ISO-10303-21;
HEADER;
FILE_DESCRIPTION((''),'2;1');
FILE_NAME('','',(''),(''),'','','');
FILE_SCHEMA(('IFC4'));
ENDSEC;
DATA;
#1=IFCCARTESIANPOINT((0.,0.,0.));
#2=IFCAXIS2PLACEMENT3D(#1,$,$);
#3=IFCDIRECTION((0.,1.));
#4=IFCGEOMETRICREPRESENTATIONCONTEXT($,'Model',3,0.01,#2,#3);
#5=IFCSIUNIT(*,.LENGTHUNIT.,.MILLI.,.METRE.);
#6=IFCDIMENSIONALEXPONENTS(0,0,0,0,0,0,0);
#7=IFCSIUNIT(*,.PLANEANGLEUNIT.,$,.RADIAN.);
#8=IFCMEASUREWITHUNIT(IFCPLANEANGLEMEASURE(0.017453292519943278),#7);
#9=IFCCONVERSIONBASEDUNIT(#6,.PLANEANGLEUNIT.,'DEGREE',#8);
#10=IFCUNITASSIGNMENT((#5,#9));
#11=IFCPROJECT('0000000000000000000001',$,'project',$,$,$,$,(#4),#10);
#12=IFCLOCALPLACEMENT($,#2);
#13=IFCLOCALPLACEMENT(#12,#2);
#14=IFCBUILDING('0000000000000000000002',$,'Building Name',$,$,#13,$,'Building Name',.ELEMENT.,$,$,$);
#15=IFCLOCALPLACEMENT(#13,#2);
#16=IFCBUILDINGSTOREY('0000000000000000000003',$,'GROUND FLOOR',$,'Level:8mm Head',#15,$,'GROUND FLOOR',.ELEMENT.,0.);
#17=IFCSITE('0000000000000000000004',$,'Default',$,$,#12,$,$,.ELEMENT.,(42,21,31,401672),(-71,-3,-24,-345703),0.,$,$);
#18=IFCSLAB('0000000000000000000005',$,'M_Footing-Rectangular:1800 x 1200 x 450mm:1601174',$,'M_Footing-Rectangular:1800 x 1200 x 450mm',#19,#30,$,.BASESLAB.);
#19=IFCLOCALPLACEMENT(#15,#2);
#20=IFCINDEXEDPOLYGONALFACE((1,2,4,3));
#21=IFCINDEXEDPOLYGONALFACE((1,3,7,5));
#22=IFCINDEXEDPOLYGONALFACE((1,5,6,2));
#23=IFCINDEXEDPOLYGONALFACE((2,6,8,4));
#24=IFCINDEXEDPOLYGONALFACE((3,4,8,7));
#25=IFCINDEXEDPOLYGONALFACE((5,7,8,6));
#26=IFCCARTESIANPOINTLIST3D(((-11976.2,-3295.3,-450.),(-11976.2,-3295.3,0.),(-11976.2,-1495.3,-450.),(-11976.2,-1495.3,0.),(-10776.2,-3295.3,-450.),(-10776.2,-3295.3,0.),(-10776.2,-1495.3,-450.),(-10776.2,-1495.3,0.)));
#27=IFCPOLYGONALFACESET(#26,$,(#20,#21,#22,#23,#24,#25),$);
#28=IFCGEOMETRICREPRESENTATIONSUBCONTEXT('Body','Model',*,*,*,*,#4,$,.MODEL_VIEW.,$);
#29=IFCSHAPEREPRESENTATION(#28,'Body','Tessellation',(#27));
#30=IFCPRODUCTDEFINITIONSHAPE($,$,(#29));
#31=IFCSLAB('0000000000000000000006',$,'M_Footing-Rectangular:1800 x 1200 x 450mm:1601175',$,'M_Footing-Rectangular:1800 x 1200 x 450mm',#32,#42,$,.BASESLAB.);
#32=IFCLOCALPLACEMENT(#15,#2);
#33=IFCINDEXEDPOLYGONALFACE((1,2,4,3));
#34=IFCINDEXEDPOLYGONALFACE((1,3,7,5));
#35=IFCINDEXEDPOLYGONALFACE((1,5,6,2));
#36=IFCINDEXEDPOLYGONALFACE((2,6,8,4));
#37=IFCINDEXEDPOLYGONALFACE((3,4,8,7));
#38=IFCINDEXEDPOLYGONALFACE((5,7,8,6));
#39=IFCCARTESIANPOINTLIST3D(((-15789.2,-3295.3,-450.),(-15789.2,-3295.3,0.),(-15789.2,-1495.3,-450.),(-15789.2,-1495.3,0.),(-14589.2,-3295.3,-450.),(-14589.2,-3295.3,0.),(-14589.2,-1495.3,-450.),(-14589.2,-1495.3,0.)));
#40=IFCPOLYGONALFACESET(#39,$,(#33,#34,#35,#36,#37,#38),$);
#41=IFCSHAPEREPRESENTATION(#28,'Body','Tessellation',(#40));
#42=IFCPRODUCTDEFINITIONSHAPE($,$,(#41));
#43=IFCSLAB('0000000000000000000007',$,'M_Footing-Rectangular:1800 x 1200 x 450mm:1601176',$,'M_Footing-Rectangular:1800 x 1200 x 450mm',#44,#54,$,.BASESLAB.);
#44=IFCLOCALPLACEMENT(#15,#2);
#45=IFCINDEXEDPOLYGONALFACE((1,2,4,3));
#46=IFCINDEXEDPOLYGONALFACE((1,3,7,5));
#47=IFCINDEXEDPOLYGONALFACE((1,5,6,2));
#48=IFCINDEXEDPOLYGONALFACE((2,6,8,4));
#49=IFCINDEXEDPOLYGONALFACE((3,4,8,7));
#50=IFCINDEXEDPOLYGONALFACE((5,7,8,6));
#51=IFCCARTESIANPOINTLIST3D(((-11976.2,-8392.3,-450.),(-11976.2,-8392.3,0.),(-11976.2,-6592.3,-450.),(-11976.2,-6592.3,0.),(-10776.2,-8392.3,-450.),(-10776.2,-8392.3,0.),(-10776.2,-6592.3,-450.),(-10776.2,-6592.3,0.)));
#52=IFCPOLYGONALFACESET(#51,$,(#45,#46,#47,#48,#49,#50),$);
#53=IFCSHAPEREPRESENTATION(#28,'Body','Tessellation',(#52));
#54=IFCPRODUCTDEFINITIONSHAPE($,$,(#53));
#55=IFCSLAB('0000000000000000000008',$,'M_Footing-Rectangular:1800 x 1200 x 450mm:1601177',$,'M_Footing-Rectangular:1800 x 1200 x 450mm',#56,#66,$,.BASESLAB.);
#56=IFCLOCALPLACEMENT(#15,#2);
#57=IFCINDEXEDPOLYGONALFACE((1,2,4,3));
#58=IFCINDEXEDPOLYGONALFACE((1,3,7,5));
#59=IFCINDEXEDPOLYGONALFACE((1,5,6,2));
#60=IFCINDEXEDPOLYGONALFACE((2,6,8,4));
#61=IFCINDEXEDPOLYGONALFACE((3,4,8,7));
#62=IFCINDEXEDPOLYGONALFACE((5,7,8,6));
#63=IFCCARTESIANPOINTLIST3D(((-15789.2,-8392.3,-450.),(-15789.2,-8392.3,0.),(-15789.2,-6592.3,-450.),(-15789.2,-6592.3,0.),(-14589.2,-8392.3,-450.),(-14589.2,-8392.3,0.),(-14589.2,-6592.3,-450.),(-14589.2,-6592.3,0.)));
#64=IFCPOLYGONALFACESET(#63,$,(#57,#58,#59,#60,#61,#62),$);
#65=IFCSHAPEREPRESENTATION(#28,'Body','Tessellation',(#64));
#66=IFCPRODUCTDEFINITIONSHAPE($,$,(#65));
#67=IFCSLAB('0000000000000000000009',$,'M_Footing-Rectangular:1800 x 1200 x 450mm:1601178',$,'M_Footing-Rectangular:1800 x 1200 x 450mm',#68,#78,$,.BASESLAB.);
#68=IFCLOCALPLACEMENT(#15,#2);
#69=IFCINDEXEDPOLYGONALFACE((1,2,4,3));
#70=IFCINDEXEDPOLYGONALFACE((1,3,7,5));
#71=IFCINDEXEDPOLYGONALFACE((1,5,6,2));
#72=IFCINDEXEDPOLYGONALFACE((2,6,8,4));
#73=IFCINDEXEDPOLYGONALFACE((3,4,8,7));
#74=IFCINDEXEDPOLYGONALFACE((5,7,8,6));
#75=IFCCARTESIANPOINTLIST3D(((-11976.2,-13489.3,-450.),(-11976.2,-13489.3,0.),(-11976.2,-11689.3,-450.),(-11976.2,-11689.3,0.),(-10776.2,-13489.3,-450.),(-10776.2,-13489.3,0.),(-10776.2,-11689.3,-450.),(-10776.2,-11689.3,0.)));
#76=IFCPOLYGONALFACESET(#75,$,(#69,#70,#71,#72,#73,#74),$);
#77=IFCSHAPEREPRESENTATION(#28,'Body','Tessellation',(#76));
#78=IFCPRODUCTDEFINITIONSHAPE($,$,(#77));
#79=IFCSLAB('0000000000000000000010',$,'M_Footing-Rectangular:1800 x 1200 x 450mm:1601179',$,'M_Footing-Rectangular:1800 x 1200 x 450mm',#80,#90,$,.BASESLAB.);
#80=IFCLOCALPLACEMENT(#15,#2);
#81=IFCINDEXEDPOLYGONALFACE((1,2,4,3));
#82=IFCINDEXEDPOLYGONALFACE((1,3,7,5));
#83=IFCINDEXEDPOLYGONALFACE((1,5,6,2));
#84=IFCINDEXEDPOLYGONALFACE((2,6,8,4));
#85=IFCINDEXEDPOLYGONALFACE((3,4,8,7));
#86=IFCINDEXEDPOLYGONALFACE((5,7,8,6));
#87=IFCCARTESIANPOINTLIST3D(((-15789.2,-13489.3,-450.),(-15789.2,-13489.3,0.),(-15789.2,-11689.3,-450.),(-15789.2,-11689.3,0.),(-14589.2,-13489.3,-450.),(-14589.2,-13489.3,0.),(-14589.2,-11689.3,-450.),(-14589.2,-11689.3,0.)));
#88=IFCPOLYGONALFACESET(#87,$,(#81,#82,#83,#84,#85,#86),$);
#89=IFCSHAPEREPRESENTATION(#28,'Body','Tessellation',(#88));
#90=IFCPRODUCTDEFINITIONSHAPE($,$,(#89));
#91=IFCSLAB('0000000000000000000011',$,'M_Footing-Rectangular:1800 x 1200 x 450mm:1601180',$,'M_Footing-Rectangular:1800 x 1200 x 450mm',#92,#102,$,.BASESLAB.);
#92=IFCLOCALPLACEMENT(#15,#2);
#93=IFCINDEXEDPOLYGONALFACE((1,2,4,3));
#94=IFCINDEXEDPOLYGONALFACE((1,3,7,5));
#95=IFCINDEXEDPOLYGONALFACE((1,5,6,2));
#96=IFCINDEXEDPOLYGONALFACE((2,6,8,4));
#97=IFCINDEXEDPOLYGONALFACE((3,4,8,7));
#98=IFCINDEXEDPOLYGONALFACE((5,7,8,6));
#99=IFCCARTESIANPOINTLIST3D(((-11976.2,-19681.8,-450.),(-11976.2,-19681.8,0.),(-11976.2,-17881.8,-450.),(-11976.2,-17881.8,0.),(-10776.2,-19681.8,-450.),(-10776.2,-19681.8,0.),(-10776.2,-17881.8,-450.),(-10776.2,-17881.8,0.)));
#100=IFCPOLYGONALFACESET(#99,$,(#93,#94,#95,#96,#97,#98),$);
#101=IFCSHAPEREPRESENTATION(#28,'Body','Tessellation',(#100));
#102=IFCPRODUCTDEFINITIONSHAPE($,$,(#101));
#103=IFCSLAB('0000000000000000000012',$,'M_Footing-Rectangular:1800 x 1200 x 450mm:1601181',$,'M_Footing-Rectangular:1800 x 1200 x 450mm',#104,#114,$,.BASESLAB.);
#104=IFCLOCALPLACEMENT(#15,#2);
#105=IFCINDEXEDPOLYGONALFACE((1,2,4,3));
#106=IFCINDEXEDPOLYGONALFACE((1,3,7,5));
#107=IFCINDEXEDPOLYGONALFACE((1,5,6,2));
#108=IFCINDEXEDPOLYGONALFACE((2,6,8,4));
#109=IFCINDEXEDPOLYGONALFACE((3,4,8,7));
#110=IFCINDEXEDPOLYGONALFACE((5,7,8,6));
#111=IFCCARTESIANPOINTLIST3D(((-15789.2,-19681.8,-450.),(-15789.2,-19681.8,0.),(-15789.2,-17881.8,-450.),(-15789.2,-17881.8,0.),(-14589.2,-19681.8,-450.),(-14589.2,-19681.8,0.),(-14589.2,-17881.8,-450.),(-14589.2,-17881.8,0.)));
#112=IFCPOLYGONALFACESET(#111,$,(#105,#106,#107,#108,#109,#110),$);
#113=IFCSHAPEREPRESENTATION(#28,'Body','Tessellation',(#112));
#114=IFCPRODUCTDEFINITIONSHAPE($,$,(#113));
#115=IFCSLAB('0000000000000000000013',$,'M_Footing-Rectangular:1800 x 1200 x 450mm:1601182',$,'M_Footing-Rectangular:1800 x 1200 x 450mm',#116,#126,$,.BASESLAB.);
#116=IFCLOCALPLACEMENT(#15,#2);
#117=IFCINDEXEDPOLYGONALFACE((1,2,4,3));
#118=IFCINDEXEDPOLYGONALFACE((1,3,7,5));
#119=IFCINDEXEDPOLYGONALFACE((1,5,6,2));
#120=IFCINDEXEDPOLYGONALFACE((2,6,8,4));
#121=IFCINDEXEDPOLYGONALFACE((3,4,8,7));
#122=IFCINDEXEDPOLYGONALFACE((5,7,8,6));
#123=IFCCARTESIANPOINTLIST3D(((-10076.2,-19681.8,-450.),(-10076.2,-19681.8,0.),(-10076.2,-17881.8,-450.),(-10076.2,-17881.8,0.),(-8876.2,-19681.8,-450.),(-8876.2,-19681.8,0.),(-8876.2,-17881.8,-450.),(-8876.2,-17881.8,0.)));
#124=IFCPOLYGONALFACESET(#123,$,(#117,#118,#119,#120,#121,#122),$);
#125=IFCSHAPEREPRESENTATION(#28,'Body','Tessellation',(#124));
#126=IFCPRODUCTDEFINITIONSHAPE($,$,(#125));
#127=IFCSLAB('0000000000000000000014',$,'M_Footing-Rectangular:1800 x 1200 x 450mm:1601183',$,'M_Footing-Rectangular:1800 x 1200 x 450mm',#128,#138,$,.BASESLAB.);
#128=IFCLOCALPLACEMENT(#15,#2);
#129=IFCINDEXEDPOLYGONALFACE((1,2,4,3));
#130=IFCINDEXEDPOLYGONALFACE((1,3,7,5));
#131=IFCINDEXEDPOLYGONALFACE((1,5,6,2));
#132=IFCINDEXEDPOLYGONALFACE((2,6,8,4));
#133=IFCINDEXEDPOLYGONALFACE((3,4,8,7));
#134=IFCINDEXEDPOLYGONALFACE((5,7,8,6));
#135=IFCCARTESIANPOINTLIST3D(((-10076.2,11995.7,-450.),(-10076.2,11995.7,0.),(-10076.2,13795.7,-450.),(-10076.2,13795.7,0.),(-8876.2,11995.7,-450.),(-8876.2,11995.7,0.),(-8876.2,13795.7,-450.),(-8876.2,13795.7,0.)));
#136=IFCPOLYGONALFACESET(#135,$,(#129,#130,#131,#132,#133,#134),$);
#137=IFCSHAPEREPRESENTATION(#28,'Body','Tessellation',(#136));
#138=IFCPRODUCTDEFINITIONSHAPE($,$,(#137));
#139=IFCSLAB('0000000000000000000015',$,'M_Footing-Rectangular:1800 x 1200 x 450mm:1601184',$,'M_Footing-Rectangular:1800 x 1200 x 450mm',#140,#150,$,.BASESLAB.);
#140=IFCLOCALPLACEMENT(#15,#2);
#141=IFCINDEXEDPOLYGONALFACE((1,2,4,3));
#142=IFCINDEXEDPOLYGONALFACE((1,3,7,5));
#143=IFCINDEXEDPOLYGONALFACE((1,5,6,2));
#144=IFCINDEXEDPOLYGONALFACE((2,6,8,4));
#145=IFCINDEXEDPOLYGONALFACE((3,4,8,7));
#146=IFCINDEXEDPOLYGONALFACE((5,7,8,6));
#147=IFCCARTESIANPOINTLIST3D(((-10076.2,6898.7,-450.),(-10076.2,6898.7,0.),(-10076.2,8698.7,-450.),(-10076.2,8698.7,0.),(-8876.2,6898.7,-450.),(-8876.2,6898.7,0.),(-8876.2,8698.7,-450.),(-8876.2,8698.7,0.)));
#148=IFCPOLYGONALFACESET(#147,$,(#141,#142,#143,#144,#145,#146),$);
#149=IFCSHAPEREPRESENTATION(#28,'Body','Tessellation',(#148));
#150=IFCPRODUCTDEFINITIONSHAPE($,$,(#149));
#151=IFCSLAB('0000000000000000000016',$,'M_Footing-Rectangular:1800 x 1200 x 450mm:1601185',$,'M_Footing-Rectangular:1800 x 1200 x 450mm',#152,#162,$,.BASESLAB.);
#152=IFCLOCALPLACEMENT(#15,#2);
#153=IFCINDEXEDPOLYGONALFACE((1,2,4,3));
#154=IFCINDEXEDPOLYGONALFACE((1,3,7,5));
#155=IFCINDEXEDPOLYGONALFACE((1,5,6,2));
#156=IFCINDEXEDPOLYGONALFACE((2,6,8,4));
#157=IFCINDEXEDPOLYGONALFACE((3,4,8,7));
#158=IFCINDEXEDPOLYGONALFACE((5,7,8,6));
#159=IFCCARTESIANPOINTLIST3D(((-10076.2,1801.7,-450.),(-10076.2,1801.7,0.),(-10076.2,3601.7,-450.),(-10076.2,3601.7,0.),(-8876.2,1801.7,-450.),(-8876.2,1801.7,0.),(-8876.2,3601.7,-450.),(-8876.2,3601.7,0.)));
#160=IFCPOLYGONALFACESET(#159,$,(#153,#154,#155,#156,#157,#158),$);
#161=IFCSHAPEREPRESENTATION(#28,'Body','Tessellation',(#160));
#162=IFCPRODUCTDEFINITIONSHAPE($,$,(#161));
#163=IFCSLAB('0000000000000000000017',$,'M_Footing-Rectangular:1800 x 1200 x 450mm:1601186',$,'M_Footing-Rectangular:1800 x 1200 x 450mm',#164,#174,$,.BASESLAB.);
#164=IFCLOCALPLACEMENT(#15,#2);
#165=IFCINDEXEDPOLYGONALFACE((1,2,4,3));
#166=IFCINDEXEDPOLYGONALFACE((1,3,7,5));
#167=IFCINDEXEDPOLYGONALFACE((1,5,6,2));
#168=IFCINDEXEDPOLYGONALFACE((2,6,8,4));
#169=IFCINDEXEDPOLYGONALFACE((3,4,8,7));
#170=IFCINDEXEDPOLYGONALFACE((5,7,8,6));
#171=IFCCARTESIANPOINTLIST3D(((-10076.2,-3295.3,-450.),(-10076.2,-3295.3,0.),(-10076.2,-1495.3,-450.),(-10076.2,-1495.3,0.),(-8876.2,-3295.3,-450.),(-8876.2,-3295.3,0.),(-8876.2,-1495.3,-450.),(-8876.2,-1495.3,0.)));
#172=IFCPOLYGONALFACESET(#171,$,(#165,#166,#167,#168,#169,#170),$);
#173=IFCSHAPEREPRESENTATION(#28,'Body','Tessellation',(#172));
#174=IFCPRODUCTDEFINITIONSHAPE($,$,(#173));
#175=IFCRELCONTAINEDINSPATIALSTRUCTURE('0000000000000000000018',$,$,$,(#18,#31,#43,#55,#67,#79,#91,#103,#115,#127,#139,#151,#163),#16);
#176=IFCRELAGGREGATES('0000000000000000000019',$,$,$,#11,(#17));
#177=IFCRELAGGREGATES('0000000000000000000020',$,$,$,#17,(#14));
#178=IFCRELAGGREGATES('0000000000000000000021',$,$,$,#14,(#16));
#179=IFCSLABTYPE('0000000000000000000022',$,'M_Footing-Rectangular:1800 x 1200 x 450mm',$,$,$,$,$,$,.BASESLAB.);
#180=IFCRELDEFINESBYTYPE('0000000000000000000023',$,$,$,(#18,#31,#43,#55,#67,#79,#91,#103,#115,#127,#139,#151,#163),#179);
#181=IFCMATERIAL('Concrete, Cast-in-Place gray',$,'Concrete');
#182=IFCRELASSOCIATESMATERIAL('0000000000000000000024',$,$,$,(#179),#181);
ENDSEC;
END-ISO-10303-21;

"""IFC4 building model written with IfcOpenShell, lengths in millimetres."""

from ifc_helpers import new_model, entity, si_unit, converted_unit, direction, frame, origin, place, context, subcontext, project, spatial, indexed_curve, outline, extrude, material, type_object, element, save


model = new_model("IFC4")

# Units and contexts
model_context = context("Model", 3, precision=0.01, world=origin(), true_north=direction((0.0, 1.0)))
body_context = subcontext(model_context, "Body", "Model", "MODEL_VIEW")
ifc_project = project(units=[si_unit("LENGTHUNIT", "METRE", prefix="MILLI"), converted_unit("PLANEANGLEUNIT", "DEGREE", entity("IfcPlaneAngleMeasure", 0.017453292519943278), si_unit("PLANEANGLEUNIT", "RADIAN"), dimensions=[0, 0, 0, 0, 0, 0, 0])], contexts=[model_context])

# Site, building, storey
site_placement = place(None, origin())
site = spatial("IfcSite", under=ifc_project, at=site_placement, Name="Default", CompositionType="ELEMENT", RefLatitude=(42, 21, 31, 401672), RefLongitude=(-71, -3, -24, -345703), RefElevation=0.0)
building_placement = place(site_placement, origin())
building = spatial("IfcBuilding", under=site, at=building_placement, Name="Building Name", LongName="Building Name", CompositionType="ELEMENT")
storey_placement = place(building_placement, origin())
storey = spatial("IfcBuildingStorey", under=building, at=storey_placement, Name="GROUND FLOOR", ObjectType="Level:8mm Head", LongName="GROUND FLOOR", CompositionType="ELEMENT", Elevation=0.0)

# Shared definitions
ifc_material_1 = material(Name="Concrete, Cast-in-Place gray", Category="Concrete")

# Slabs
slab_type_1 = type_object("IfcSlabType", Name="M_Footing-Rectangular:1800 x 1200 x 450mm", PredefinedType="BASESLAB", material=ifc_material_1)
slab_1_placement = place(storey_placement, origin())
element("IfcSlab", 1, at=slab_1_placement, inside=storey, type_object=slab_type_1, Name="M_Footing-Rectangular:1800 x 1200 x 450mm:1601174", ObjectType="M_Footing-Rectangular:1800 x 1200 x 450mm", PredefinedType="BASESLAB", context=body_context, shape_type="SweptSolid", body=[
    extrude(outline(indexed_curve([(-600.0, -900.0), (600.0, -900.0), (600.0, 900.0), (-600.0, 900.0), (-600.0, -900.0)], self_intersect=False)), frame((-11376.2, -2395.3, -450.0), z_axis=(0.0, 0.0, 1.0), x_axis=(-1.0, 0.0, 0.0)), (0.0, 0.0, 1.0), 450.0),
])
slab_2_placement = place(storey_placement, origin())
element("IfcSlab", 2, at=slab_2_placement, inside=storey, type_object=slab_type_1, Name="M_Footing-Rectangular:1800 x 1200 x 450mm:1601175", ObjectType="M_Footing-Rectangular:1800 x 1200 x 450mm", PredefinedType="BASESLAB", context=body_context, shape_type="SweptSolid", body=[
    extrude(outline(indexed_curve([(-600.0, -900.0), (600.0, -900.0), (600.0, 900.0), (-600.0, 900.0), (-600.0, -900.0)], self_intersect=False)), frame((-15189.2, -2395.3, -450.0), z_axis=(0.0, 0.0, 1.0), x_axis=(-1.0, 0.0, 0.0)), (0.0, 0.0, 1.0), 450.0),
])
slab_3_placement = place(storey_placement, origin())
element("IfcSlab", 3, at=slab_3_placement, inside=storey, type_object=slab_type_1, Name="M_Footing-Rectangular:1800 x 1200 x 450mm:1601176", ObjectType="M_Footing-Rectangular:1800 x 1200 x 450mm", PredefinedType="BASESLAB", context=body_context, shape_type="SweptSolid", body=[
    extrude(outline(indexed_curve([(-600.0, -900.0), (600.0, -900.0), (600.0, 900.0), (-600.0, 900.0), (-600.0, -900.0)], self_intersect=False)), frame((-11376.2, -7492.3, -450.0), z_axis=(0.0, 0.0, 1.0), x_axis=(-1.0, 0.0, 0.0)), (0.0, 0.0, 1.0), 450.0),
])
slab_4_placement = place(storey_placement, origin())
element("IfcSlab", 4, at=slab_4_placement, inside=storey, type_object=slab_type_1, Name="M_Footing-Rectangular:1800 x 1200 x 450mm:1601177", ObjectType="M_Footing-Rectangular:1800 x 1200 x 450mm", PredefinedType="BASESLAB", context=body_context, shape_type="SweptSolid", body=[
    extrude(outline(indexed_curve([(-600.0, -900.0), (600.0, -900.0), (600.0, 900.0), (-600.0, 900.0), (-600.0, -900.0)], self_intersect=False)), frame((-15189.2, -7492.3, -450.0), z_axis=(0.0, 0.0, 1.0), x_axis=(-1.0, 0.0, 0.0)), (0.0, 0.0, 1.0), 450.0),
])
slab_5_placement = place(storey_placement, origin())
element("IfcSlab", 5, at=slab_5_placement, inside=storey, type_object=slab_type_1, Name="M_Footing-Rectangular:1800 x 1200 x 450mm:1601178", ObjectType="M_Footing-Rectangular:1800 x 1200 x 450mm", PredefinedType="BASESLAB", context=body_context, shape_type="SweptSolid", body=[
    extrude(outline(indexed_curve([(-600.0, -900.0), (600.0, -900.0), (600.0, 900.0), (-600.0, 900.0), (-600.0, -900.0)], self_intersect=False)), frame((-11376.2, -12589.3, -450.0), z_axis=(0.0, 0.0, 1.0), x_axis=(-1.0, 0.0, 0.0)), (0.0, 0.0, 1.0), 450.0),
])
slab_6_placement = place(storey_placement, origin())
element("IfcSlab", 6, at=slab_6_placement, inside=storey, type_object=slab_type_1, Name="M_Footing-Rectangular:1800 x 1200 x 450mm:1601179", ObjectType="M_Footing-Rectangular:1800 x 1200 x 450mm", PredefinedType="BASESLAB", context=body_context, shape_type="SweptSolid", body=[
    extrude(outline(indexed_curve([(-600.0, -900.0), (600.0, -900.0), (600.0, 900.0), (-600.0, 900.0), (-600.0, -900.0)], self_intersect=False)), frame((-15189.2, -12589.3, -450.0), z_axis=(0.0, 0.0, 1.0), x_axis=(-1.0, 0.0, 0.0)), (0.0, 0.0, 1.0), 450.0),
])
slab_7_placement = place(storey_placement, origin())
element("IfcSlab", 7, at=slab_7_placement, inside=storey, type_object=slab_type_1, Name="M_Footing-Rectangular:1800 x 1200 x 450mm:1601180", ObjectType="M_Footing-Rectangular:1800 x 1200 x 450mm", PredefinedType="BASESLAB", context=body_context, shape_type="SweptSolid", body=[
    extrude(outline(indexed_curve([(-600.0, -900.0), (600.0, -900.0), (600.0, 900.0), (-600.0, 900.0), (-600.0, -900.0)], self_intersect=False)), frame((-11376.2, -18781.8, -450.0), z_axis=(0.0, 0.0, 1.0), x_axis=(-1.0, 0.0, 0.0)), (0.0, 0.0, 1.0), 450.0),
])
slab_8_placement = place(storey_placement, origin())
element("IfcSlab", 8, at=slab_8_placement, inside=storey, type_object=slab_type_1, Name="M_Footing-Rectangular:1800 x 1200 x 450mm:1601181", ObjectType="M_Footing-Rectangular:1800 x 1200 x 450mm", PredefinedType="BASESLAB", context=body_context, shape_type="SweptSolid", body=[
    extrude(outline(indexed_curve([(-600.0, -900.0), (600.0, -900.0), (600.0, 900.0), (-600.0, 900.0), (-600.0, -900.0)], self_intersect=False)), frame((-15189.2, -18781.8, -450.0), z_axis=(0.0, 0.0, 1.0), x_axis=(-1.0, 0.0, 0.0)), (0.0, 0.0, 1.0), 450.0),
])
slab_9_placement = place(storey_placement, origin())
element("IfcSlab", 9, at=slab_9_placement, inside=storey, type_object=slab_type_1, Name="M_Footing-Rectangular:1800 x 1200 x 450mm:1601182", ObjectType="M_Footing-Rectangular:1800 x 1200 x 450mm", PredefinedType="BASESLAB", context=body_context, shape_type="SweptSolid", body=[
    extrude(outline(indexed_curve([(-600.0, -900.0), (600.0, -900.0), (600.0, 900.0), (-600.0, 900.0), (-600.0, -900.0)], self_intersect=False)), frame((-9476.2, -18781.8, -450.0), z_axis=(0.0, 0.0, 1.0), x_axis=(-1.0, 0.0, 0.0)), (0.0, 0.0, 1.0), 450.0),
])
slab_10_placement = place(storey_placement, origin())
element("IfcSlab", 10, at=slab_10_placement, inside=storey, type_object=slab_type_1, Name="M_Footing-Rectangular:1800 x 1200 x 450mm:1601183", ObjectType="M_Footing-Rectangular:1800 x 1200 x 450mm", PredefinedType="BASESLAB", context=body_context, shape_type="SweptSolid", body=[
    extrude(outline(indexed_curve([(-600.0, -900.0), (600.0, -900.0), (600.0, 900.0), (-600.0, 900.0), (-600.0, -900.0)], self_intersect=False)), frame((-9476.2, 12895.7, -450.0), z_axis=(0.0, 0.0, 1.0), x_axis=(-1.0, 0.0, 0.0)), (0.0, 0.0, 1.0), 450.0),
])
slab_11_placement = place(storey_placement, origin())
element("IfcSlab", 11, at=slab_11_placement, inside=storey, type_object=slab_type_1, Name="M_Footing-Rectangular:1800 x 1200 x 450mm:1601184", ObjectType="M_Footing-Rectangular:1800 x 1200 x 450mm", PredefinedType="BASESLAB", context=body_context, shape_type="SweptSolid", body=[
    extrude(outline(indexed_curve([(-600.0, -900.0), (600.0, -900.0), (600.0, 900.0), (-600.0, 900.0), (-600.0, -900.0)], self_intersect=False)), frame((-9476.2, 7798.7, -450.0), z_axis=(0.0, 0.0, 1.0), x_axis=(-1.0, 0.0, 0.0)), (0.0, 0.0, 1.0), 450.0),
])
slab_12_placement = place(storey_placement, origin())
element("IfcSlab", 12, at=slab_12_placement, inside=storey, type_object=slab_type_1, Name="M_Footing-Rectangular:1800 x 1200 x 450mm:1601185", ObjectType="M_Footing-Rectangular:1800 x 1200 x 450mm", PredefinedType="BASESLAB", context=body_context, shape_type="SweptSolid", body=[
    extrude(outline(indexed_curve([(-600.0, -900.0), (600.0, -900.0), (600.0, 900.0), (-600.0, 900.0), (-600.0, -900.0)], self_intersect=False)), frame((-9476.2, 2701.7, -450.0), z_axis=(0.0, 0.0, 1.0), x_axis=(-1.0, 0.0, 0.0)), (0.0, 0.0, 1.0), 450.0),
])
slab_13_placement = place(storey_placement, origin())
element("IfcSlab", 13, at=slab_13_placement, inside=storey, type_object=slab_type_1, Name="M_Footing-Rectangular:1800 x 1200 x 450mm:1601186", ObjectType="M_Footing-Rectangular:1800 x 1200 x 450mm", PredefinedType="BASESLAB", context=body_context, shape_type="SweptSolid", body=[
    extrude(outline(indexed_curve([(-600.0, -900.0), (600.0, -900.0), (600.0, 900.0), (-600.0, 900.0), (-600.0, -900.0)], self_intersect=False)), frame((-9476.2, -2395.3, -450.0), z_axis=(0.0, 0.0, 1.0), x_axis=(-1.0, 0.0, 0.0)), (0.0, 0.0, 1.0), 450.0),
])

save(model, "model.ifc")
